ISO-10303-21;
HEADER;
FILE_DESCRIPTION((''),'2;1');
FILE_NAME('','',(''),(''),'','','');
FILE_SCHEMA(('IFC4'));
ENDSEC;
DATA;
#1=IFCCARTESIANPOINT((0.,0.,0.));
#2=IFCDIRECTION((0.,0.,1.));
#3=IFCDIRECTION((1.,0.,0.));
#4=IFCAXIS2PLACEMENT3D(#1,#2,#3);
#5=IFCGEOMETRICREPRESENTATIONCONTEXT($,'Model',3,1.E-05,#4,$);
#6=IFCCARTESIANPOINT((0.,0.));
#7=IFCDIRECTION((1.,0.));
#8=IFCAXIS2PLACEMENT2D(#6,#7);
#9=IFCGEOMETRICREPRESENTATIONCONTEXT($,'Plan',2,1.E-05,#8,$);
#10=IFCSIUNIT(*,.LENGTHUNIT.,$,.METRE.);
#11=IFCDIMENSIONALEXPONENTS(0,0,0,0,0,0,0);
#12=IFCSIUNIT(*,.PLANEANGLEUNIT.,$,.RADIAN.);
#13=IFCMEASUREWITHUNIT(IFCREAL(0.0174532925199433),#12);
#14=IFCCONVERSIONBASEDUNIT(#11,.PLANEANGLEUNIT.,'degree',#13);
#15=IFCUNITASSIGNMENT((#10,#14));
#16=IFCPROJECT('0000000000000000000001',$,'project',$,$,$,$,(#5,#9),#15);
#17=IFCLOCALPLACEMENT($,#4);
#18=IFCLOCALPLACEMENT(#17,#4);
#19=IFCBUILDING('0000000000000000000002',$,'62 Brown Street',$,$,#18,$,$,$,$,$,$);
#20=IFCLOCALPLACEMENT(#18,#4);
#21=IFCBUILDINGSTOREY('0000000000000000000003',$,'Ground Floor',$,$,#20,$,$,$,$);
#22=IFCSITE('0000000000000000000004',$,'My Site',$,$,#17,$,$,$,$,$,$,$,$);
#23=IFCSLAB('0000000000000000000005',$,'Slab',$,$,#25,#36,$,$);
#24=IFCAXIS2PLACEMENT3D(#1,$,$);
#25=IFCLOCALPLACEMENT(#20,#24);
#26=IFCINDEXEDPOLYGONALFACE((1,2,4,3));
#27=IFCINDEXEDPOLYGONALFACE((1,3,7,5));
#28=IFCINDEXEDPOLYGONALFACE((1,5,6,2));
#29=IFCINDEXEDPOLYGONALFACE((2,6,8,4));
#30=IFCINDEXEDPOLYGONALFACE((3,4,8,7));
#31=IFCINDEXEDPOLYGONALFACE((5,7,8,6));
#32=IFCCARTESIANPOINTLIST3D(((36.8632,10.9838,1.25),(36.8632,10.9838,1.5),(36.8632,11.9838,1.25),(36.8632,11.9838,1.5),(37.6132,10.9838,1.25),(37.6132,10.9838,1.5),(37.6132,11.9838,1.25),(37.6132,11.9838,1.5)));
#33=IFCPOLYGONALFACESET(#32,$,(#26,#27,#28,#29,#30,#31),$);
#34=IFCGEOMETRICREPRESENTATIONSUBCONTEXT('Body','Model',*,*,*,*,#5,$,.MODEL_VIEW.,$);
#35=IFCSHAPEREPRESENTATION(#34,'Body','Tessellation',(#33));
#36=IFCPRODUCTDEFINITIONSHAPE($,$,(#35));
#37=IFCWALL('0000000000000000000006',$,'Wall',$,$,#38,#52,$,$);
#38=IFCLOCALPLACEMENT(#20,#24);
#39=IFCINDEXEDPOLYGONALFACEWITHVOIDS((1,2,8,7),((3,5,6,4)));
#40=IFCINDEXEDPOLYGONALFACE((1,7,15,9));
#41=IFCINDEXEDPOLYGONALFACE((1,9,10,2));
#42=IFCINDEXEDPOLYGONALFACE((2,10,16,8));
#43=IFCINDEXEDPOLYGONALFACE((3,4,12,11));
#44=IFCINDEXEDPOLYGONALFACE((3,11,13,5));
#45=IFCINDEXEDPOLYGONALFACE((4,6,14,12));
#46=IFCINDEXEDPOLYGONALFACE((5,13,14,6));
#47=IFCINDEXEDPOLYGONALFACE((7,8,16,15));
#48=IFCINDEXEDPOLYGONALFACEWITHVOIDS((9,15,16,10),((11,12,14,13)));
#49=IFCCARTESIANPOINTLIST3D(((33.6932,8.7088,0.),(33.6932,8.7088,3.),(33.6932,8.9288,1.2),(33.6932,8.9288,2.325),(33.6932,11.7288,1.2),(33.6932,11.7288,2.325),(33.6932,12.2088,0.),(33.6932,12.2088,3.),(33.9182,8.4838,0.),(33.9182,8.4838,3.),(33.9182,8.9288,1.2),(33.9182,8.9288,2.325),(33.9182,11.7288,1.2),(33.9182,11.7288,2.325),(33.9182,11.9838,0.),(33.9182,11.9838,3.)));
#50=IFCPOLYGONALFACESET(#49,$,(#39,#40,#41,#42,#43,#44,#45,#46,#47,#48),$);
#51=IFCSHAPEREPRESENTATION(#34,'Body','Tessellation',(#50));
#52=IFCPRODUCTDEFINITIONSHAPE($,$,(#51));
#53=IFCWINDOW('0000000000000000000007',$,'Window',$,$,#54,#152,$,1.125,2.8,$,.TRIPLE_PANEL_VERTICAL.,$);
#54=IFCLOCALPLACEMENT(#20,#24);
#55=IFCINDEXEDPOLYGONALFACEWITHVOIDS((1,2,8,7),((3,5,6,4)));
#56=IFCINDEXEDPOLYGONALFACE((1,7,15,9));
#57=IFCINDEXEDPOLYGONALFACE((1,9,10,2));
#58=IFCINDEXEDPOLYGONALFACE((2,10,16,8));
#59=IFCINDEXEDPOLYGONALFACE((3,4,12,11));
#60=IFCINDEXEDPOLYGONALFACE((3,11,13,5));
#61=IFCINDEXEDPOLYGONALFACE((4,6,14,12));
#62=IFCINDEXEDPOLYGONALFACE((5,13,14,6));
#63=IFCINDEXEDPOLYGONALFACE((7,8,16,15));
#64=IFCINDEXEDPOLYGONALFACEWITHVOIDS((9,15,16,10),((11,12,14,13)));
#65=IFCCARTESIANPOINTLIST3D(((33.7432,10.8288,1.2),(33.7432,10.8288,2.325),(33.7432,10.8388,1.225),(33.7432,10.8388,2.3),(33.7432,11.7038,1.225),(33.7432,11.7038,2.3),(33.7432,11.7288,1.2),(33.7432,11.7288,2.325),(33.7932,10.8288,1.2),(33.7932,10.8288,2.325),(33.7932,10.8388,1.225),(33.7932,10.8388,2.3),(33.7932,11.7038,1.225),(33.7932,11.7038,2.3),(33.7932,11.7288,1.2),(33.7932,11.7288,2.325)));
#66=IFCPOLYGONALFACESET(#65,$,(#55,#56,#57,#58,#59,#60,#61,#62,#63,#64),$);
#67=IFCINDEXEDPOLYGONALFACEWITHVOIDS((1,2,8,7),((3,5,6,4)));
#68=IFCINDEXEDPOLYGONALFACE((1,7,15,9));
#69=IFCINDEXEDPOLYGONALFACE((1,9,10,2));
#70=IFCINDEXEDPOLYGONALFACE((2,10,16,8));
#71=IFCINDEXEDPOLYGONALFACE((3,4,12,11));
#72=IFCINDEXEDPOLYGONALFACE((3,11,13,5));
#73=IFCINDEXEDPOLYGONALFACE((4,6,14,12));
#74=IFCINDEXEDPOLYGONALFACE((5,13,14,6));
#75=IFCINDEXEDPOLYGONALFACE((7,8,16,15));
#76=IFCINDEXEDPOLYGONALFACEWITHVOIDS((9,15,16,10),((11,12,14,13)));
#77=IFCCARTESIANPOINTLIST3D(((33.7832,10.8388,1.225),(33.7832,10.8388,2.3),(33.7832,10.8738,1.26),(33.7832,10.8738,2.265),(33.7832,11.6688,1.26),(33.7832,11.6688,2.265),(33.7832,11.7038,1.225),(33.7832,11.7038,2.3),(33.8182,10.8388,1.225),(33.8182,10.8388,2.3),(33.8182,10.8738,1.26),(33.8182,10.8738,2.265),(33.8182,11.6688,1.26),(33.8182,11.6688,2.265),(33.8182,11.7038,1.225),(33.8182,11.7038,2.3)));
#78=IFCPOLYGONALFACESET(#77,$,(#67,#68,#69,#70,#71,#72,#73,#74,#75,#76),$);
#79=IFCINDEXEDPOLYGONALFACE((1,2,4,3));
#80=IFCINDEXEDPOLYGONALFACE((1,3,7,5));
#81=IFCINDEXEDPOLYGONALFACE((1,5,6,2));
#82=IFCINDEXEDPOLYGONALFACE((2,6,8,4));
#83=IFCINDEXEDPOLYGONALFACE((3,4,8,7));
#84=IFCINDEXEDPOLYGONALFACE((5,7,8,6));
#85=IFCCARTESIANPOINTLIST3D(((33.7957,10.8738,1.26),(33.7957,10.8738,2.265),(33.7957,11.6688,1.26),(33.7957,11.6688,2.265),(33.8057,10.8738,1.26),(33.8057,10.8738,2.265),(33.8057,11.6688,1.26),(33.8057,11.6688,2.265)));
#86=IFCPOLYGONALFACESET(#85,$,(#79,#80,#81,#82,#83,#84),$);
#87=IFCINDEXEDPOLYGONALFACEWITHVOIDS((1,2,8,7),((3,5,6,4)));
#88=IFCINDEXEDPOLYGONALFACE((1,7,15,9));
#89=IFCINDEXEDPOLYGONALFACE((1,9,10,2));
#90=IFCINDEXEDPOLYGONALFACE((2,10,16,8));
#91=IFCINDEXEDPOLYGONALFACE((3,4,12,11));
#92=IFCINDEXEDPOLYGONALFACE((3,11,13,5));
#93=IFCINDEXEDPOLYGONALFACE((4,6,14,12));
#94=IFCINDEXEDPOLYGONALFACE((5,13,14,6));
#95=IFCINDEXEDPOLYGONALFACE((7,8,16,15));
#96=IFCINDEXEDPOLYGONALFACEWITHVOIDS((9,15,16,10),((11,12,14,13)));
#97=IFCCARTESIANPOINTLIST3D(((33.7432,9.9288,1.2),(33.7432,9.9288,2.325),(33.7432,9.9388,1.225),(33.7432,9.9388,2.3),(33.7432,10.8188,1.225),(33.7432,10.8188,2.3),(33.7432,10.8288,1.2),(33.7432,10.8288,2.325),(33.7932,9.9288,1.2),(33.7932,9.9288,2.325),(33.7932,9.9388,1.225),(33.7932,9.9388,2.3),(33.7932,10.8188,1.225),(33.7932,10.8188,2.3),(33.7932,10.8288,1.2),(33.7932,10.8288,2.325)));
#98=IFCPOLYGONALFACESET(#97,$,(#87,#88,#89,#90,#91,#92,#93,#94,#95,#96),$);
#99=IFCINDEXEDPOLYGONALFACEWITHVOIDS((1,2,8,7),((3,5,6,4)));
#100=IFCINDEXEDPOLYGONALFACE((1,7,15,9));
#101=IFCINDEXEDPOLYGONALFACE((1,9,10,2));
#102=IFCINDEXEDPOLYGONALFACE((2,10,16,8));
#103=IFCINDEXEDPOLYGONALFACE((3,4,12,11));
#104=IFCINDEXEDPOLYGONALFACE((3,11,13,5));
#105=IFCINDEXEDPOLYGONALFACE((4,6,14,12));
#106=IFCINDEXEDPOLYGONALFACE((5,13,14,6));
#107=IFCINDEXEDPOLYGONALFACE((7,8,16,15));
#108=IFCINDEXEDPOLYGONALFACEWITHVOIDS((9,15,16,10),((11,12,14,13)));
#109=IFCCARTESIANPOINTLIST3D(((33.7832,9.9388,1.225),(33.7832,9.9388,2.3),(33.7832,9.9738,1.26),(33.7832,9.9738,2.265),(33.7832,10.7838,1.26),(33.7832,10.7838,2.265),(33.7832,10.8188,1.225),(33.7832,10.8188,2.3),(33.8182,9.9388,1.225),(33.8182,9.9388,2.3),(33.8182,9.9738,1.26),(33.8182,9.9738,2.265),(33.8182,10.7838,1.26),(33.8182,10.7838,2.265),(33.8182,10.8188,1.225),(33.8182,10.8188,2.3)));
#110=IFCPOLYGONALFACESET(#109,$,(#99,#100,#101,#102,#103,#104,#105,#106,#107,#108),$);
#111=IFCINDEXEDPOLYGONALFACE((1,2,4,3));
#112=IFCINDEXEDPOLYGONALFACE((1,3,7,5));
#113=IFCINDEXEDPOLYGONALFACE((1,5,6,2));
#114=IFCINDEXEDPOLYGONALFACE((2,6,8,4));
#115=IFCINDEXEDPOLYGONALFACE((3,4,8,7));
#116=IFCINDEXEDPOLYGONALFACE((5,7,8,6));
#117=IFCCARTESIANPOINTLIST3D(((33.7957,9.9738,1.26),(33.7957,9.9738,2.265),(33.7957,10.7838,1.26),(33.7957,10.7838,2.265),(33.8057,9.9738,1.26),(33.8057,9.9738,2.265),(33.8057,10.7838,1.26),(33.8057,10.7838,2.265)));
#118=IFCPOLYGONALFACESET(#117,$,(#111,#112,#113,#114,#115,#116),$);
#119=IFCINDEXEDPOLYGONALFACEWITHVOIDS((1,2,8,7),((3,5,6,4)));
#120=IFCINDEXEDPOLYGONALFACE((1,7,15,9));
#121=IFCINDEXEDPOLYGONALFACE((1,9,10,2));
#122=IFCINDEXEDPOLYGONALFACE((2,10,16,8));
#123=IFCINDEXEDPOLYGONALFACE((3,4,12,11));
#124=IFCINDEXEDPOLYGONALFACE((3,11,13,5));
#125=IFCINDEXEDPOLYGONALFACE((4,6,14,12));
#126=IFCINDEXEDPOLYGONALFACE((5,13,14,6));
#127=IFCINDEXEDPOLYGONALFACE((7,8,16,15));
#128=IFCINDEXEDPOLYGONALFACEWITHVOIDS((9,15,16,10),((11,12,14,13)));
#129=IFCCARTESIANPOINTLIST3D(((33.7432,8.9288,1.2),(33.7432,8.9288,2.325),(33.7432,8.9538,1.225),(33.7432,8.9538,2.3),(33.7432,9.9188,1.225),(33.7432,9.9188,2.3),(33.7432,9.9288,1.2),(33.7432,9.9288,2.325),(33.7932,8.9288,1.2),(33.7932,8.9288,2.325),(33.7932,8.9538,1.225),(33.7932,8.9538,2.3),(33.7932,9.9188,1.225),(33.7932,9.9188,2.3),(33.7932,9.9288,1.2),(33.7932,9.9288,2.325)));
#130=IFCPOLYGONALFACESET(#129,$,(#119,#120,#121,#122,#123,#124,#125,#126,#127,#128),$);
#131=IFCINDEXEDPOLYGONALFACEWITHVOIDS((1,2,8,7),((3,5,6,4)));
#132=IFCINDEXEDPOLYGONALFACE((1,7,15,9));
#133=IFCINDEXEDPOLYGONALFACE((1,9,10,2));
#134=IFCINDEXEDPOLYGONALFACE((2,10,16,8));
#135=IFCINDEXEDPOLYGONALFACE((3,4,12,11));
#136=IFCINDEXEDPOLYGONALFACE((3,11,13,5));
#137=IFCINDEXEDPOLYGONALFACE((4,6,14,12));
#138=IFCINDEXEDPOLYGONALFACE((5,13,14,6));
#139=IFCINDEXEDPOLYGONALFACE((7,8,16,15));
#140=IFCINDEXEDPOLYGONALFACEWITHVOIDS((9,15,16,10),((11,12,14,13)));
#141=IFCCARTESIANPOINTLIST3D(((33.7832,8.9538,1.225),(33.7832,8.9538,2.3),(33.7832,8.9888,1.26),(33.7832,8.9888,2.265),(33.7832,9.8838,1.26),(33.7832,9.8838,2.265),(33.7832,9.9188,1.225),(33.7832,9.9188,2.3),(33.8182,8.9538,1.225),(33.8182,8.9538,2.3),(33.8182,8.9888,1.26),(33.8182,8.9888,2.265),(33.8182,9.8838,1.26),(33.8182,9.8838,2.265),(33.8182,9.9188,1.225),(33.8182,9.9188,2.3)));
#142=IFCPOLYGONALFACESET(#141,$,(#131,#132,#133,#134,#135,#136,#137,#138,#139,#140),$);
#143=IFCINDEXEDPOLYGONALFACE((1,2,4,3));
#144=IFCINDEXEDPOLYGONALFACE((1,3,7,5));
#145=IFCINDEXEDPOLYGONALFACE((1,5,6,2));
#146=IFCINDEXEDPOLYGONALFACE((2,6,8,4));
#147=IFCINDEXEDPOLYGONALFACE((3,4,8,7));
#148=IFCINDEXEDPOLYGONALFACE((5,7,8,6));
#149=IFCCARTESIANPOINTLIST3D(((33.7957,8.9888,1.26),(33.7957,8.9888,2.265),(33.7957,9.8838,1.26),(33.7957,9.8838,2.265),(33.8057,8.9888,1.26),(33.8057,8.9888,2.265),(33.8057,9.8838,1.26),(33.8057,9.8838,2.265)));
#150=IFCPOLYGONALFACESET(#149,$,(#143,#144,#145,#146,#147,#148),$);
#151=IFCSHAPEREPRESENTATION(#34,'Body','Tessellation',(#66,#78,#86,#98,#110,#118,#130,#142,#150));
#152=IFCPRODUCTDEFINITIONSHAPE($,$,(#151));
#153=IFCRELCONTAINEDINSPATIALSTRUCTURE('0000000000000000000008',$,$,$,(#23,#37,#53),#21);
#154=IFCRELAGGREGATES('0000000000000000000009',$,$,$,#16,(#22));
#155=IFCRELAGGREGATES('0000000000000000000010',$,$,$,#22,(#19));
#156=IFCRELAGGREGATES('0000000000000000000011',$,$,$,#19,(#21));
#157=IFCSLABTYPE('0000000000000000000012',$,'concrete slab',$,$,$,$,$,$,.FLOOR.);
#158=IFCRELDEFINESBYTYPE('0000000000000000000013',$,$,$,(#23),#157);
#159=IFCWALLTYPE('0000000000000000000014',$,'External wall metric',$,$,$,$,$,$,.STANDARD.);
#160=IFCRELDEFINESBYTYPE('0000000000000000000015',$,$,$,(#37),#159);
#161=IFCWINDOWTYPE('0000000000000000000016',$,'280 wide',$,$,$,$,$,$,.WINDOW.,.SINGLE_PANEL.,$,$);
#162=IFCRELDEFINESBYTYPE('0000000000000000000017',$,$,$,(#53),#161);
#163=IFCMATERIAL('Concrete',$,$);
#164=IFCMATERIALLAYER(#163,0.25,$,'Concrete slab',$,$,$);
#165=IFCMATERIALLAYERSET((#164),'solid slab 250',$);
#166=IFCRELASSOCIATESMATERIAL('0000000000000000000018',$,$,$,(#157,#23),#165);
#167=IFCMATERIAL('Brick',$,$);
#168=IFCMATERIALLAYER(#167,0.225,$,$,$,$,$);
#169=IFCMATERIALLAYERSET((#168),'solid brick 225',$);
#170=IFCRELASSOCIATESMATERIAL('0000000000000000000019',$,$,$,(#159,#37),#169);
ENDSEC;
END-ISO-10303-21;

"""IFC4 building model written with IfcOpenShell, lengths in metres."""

from ifc_helpers import new_model, entity, si_unit, converted_unit, frame, origin_with_axes, origin_2d_with_axis, place, context, subcontext, project, spatial, line, indexed_curve, outline, extrude, clip, halfspace, shape, source, transform, mapped, material, layer, layer_set, layer_usage, type_object, type_shapes, element, fill, save


model = new_model("IFC4")

# Units and contexts
model_context = context("Model", 3, precision=1e-05, world=origin_with_axes())
plan_context = context("Plan", 2, precision=1e-05, world=origin_2d_with_axis())
body_context_1 = subcontext(model_context, "Body", "Model", "MODEL_VIEW")
body_context_2 = subcontext(plan_context, "Body", "Plan", "PLAN_VIEW")
ifc_project = project(units=[si_unit("LENGTHUNIT", "METRE"), converted_unit("PLANEANGLEUNIT", "degree", entity("IfcReal", 0.0174532925199433), si_unit("PLANEANGLEUNIT", "RADIAN"), dimensions=[0, 0, 0, 0, 0, 0, 0])], contexts=[model_context, plan_context])

# Site, building, storey
site_placement = place(None, origin_with_axes())
site = spatial("IfcSite", under=ifc_project, at=site_placement, Name="My Site")
building_placement = place(site_placement, origin_with_axes())
building = spatial("IfcBuilding", under=site, at=building_placement, Name="62 Brown Street")
storey_placement = place(building_placement, origin_with_axes())
storey = spatial("IfcBuildingStorey", under=building, at=storey_placement, Name="Ground Floor")

# Slab
ifc_material_1 = material(Name="Concrete")
ifc_layer_1 = layer(ifc_material_1, 0.25, Name="Concrete slab")
ifc_layer_set_1 = layer_set([ifc_layer_1], Name="solid slab 250")
ifc_layer_usage_1 = layer_usage(ifc_layer_set_1, "AXIS3", "POSITIVE", 0.0)
slab_type = type_object("IfcSlabType", Name="concrete slab", PredefinedType="FLOOR", material=ifc_layer_set_1)
slab_placement = place(storey_placement, frame((36.8632, 10.9838, 1.25), z_axis=(0.0, 0.0, 1.0), x_axis=(1.0, 0.0, 0.0)))
element("IfcSlab", 1, at=slab_placement, inside=storey, type_object=slab_type, material=ifc_layer_usage_1, Name="Slab", context=body_context_1, shape_type="SweptSolid", body=[
    extrude(outline(indexed_curve([(0.0, 0.0), (0.75, 0.0), (0.75, 1.0), (0.0, 1.0)], segments=[line(4, 1), line(1, 2), line(2, 3), line(3, 4)], self_intersect=False)), None, (0.0, 0.0, 1.0), 0.25),
])

# Wall, opening, window
ifc_material_2 = material(Name="Brick")
ifc_layer_2 = layer(ifc_material_2, 0.225)
ifc_layer_set_2 = layer_set([ifc_layer_2], Name="solid brick 225")
ifc_layer_usage_2 = layer_usage(ifc_layer_set_2, "AXIS2", "POSITIVE", 0.0)
wall_type_1 = type_object("IfcWallType", Name="External wall metric", PredefinedType="STANDARD", material=ifc_layer_set_2)
wall_1_placement = place(storey_placement, frame((33.6932, 12.2088, 0.0), z_axis=(0.0, 0.0, 1.0), x_axis=(0.0, -1.0, 0.0)))
wall_1 = element("IfcWall", 2, at=wall_1_placement, inside=storey, type_object=wall_type_1, material=ifc_layer_usage_2, Name="Wall", context=body_context_1, shape_type="Clipping", body=[
    clip(clip(extrude(outline(indexed_curve([(0.0, 0.0), (0.0, 0.225), (3.725, 0.225), (3.725, 0.0), (0.0, 0.0)], self_intersect=False)), origin_with_axes(), (0.0, 0.0, 1.0), 3.0), halfspace(frame((0.0, 0.0, 0.0), z_axis=(-0.674995, 0.675001, 0.0), x_axis=(0.225, 0.224998, 0.0)), False)), halfspace(frame((3.5, 0.0, 0.0), z_axis=(0.674995, -0.674999, 0.0), x_axis=(0.225, 0.224998, 0.0)), False)),
])
shared_shape_1 = source(origin_with_axes(), body_context_1, "Body", "SweptSolid", [
    extrude(outline(indexed_curve([(0.0, 0.0), (2.8, 0.0), (2.8, 1.125), (0.0, 1.125)], segments=[line(1, 2, 3, 4, 1)])), frame((0.0, -0.1, 0.0), z_axis=(0.0, -1.0, 0.0), x_axis=(1.0, 0.0, 0.0)), (0.0, 0.0, -1.0), 0.425),
])
opening_1_placement = place(wall_1_placement, frame((0.48, 0.0, 1.2), z_axis=(0.0, 0.0, 1.0), x_axis=(1.0, 0.0, 0.0)))
opening_1 = element("IfcOpeningElement", 3, at=opening_1_placement, cuts=wall_1, PredefinedType="OPENING", context=body_context_1, shape_type="MappedRepresentation", body=[
    mapped(shared_shape_1, transform((0.0, 0.0, 0.0), x_axis=(1.0, 0.0, 0.0), y_axis=(0.0, 1.0, 0.0), z_axis=(0.0, 0.0, 1.0), scale=1.0)),
])
window_type_1 = type_object("IfcWindowType", Name="280 wide", PartitioningType="SINGLE_PANEL", PredefinedType="WINDOW")
shared_shape_2 = source(origin_with_axes(), body_context_1, "Body", "SweptSolid", [
    extrude(outline(indexed_curve([(0.0, 0.0), (0.9, 0.0), (0.9, 1.125), (0.0, 1.125)], segments=[line(1, 2, 3, 4, 1)]), holes=[indexed_curve([(0.025, 0.025), (0.89, 0.025), (0.89, 1.1), (0.025, 1.1)], segments=[line(1, 2, 3, 4, 1)])]), frame((0.0, 0.05, 0.0), z_axis=(0.0, -1.0, 0.0), x_axis=(1.0, 0.0, 0.0)), (0.0, 0.0, -1.0), 0.05),
    extrude(outline(indexed_curve([(0.0, 0.0), (0.865, 0.0), (0.865, 1.075), (0.0, 1.075)], segments=[line(1, 2, 3, 4, 1)]), holes=[indexed_curve([(0.035, 0.035), (0.83, 0.035), (0.83, 1.04), (0.035, 1.04)], segments=[line(1, 2, 3, 4, 1)])]), frame((0.025, 0.09, 0.025), z_axis=(0.0, -1.0, 0.0), x_axis=(1.0, 0.0, 0.0)), (0.0, 0.0, -1.0), 0.035),
    extrude(outline(indexed_curve([(0.035, 0.035), (0.83, 0.035), (0.83, 1.04), (0.035, 1.04)], segments=[line(1, 2, 3, 4, 1)])), frame((0.025, 0.1025, 0.025), z_axis=(0.0, -1.0, 0.0), x_axis=(1.0, 0.0, 0.0)), (0.0, 0.0, -1.0), 0.01),
    extrude(outline(indexed_curve([(0.0, 0.0), (0.9, 0.0), (0.9, 1.125), (0.0, 1.125)], segments=[line(1, 2, 3, 4, 1)]), holes=[indexed_curve([(0.01, 0.025), (0.89, 0.025), (0.89, 1.1), (0.01, 1.1)], segments=[line(1, 2, 3, 4, 1)])]), frame((0.9, 0.05, 0.0), z_axis=(0.0, -1.0, 0.0), x_axis=(1.0, 0.0, 0.0)), (0.0, 0.0, -1.0), 0.05),
    extrude(outline(indexed_curve([(0.0, 0.0), (0.88, 0.0), (0.88, 1.075), (0.0, 1.075)], segments=[line(1, 2, 3, 4, 1)]), holes=[indexed_curve([(0.035, 0.035), (0.845, 0.035), (0.845, 1.04), (0.035, 1.04)], segments=[line(1, 2, 3, 4, 1)])]), frame((0.91, 0.09, 0.025), z_axis=(0.0, -1.0, 0.0), x_axis=(1.0, 0.0, 0.0)), (0.0, 0.0, -1.0), 0.035),
    extrude(outline(indexed_curve([(0.035, 0.035), (0.845, 0.035), (0.845, 1.04), (0.035, 1.04)], segments=[line(1, 2, 3, 4, 1)])), frame((0.91, 0.1025, 0.025), z_axis=(0.0, -1.0, 0.0), x_axis=(1.0, 0.0, 0.0)), (0.0, 0.0, -1.0), 0.01),
    extrude(outline(indexed_curve([(0.0, 0.0), (1.0, 0.0), (1.0, 1.125), (0.0, 1.125)], segments=[line(1, 2, 3, 4, 1)]), holes=[indexed_curve([(0.01, 0.025), (0.975, 0.025), (0.975, 1.1), (0.01, 1.1)], segments=[line(1, 2, 3, 4, 1)])]), frame((1.8, 0.05, 0.0), z_axis=(0.0, -1.0, 0.0), x_axis=(1.0, 0.0, 0.0)), (0.0, 0.0, -1.0), 0.05),
    extrude(outline(indexed_curve([(0.0, 0.0), (0.965, 0.0), (0.965, 1.075), (0.0, 1.075)], segments=[line(1, 2, 3, 4, 1)]), holes=[indexed_curve([(0.035, 0.035), (0.93, 0.035), (0.93, 1.04), (0.035, 1.04)], segments=[line(1, 2, 3, 4, 1)])]), frame((1.81, 0.09, 0.025), z_axis=(0.0, -1.0, 0.0), x_axis=(1.0, 0.0, 0.0)), (0.0, 0.0, -1.0), 0.035),
    extrude(outline(indexed_curve([(0.035, 0.035), (0.93, 0.035), (0.93, 1.04), (0.035, 1.04)], segments=[line(1, 2, 3, 4, 1)])), frame((1.81, 0.1025, 0.025), z_axis=(0.0, -1.0, 0.0), x_axis=(1.0, 0.0, 0.0)), (0.0, 0.0, -1.0), 0.01),
])
shared_shape_3 = source(origin_with_axes(), body_context_2, "Body", "Curve2D", [
    entity("IfcIndexedPolyCurve", entity("IfcCartesianPointList2D", [[0.025, 0.05], [0.89, 0.05]])),
    entity("IfcIndexedPolyCurve", entity("IfcCartesianPointList2D", [[0.0, 0.1], [0.025, 0.1], [0.025, 0.05], [0.0, 0.05]]), [entity("IfcLineIndex", [1, 2, 3, 4, 1])]),
    entity("IfcIndexedPolyCurve", entity("IfcCartesianPointList2D", [[0.9, 0.1], [0.89, 0.1], [0.89, 0.05], [0.9, 0.05]])),
    entity("IfcIndexedPolyCurve", entity("IfcCartesianPointList2D", [[0.025, 0.09], [0.06, 0.09], [0.06, 0.125], [0.025, 0.125]]), [entity("IfcLineIndex", [1, 2, 3, 4, 1])]),
    entity("IfcIndexedPolyCurve", entity("IfcCartesianPointList2D", [[0.89, 0.09], [0.855, 0.09], [0.855, 0.125], [0.89, 0.125]]), [entity("IfcLineIndex", [1, 2, 3, 4, 1])]),
    entity("IfcIndexedPolyCurve", entity("IfcCartesianPointList2D", [[0.06, 0.09], [0.855, 0.09]])),
    entity("IfcIndexedPolyCurve", entity("IfcCartesianPointList2D", [[0.06, 0.125], [0.855, 0.125]])),
    entity("IfcIndexedPolyCurve", entity("IfcCartesianPointList2D", [[0.06, 0.1075], [0.855, 0.1075]])),
    entity("IfcIndexedPolyCurve", entity("IfcCartesianPointList2D", [[0.91, 0.05], [1.79, 0.05]])),
    entity("IfcIndexedPolyCurve", entity("IfcCartesianPointList2D", [[0.9, 0.1], [0.91, 0.1], [0.91, 0.05], [0.9, 0.05]])),
    entity("IfcIndexedPolyCurve", entity("IfcCartesianPointList2D", [[1.8, 0.1], [1.79, 0.1], [1.79, 0.05], [1.8, 0.05]])),
    entity("IfcIndexedPolyCurve", entity("IfcCartesianPointList2D", [[0.91, 0.09], [0.945, 0.09], [0.945, 0.125], [0.91, 0.125]]), [entity("IfcLineIndex", [1, 2, 3, 4, 1])]),
    entity("IfcIndexedPolyCurve", entity("IfcCartesianPointList2D", [[1.79, 0.09], [1.755, 0.09], [1.755, 0.125], [1.79, 0.125]]), [entity("IfcLineIndex", [1, 2, 3, 4, 1])]),
    entity("IfcIndexedPolyCurve", entity("IfcCartesianPointList2D", [[0.945, 0.09], [1.755, 0.09]])),
    entity("IfcIndexedPolyCurve", entity("IfcCartesianPointList2D", [[0.945, 0.125], [1.755, 0.125]])),
    entity("IfcIndexedPolyCurve", entity("IfcCartesianPointList2D", [[0.945, 0.1075], [1.755, 0.1075]])),
    entity("IfcIndexedPolyCurve", entity("IfcCartesianPointList2D", [[1.81, 0.05], [2.775, 0.05]])),
    entity("IfcIndexedPolyCurve", entity("IfcCartesianPointList2D", [[1.8, 0.1], [1.81, 0.1], [1.81, 0.05], [1.8, 0.05]])),
    entity("IfcIndexedPolyCurve", entity("IfcCartesianPointList2D", [[2.8, 0.1], [2.775, 0.1], [2.775, 0.05], [2.8, 0.05]]), [entity("IfcLineIndex", [1, 2, 3, 4, 1])]),
    entity("IfcIndexedPolyCurve", entity("IfcCartesianPointList2D", [[1.81, 0.09], [1.845, 0.09], [1.845, 0.125], [1.81, 0.125]]), [entity("IfcLineIndex", [1, 2, 3, 4, 1])]),
    entity("IfcIndexedPolyCurve", entity("IfcCartesianPointList2D", [[2.775, 0.09], [2.74, 0.09], [2.74, 0.125], [2.775, 0.125]]), [entity("IfcLineIndex", [1, 2, 3, 4, 1])]),
    entity("IfcIndexedPolyCurve", entity("IfcCartesianPointList2D", [[1.845, 0.09], [2.74, 0.09]])),
    entity("IfcIndexedPolyCurve", entity("IfcCartesianPointList2D", [[1.845, 0.125], [2.74, 0.125]])),
    entity("IfcIndexedPolyCurve", entity("IfcCartesianPointList2D", [[1.845, 0.1075], [2.74, 0.1075]])),
])
type_shapes(window_type_1, [shared_shape_2, shared_shape_3])
window_1_placement = place(opening_1_placement, frame((0.0, 0.0, 0.0), z_axis=(0.0, 0.0, 1.0), x_axis=(1.0, 0.0, 0.0)))
window_1 = element("IfcWindow", 4, at=window_1_placement, inside=storey, type_object=window_type_1, Name="Window", OverallHeight=1.125, OverallWidth=2.8, PartitioningType="TRIPLE_PANEL_VERTICAL", shapes=[
    shape(body_context_1, "Body", "MappedRepresentation", [mapped(shared_shape_2, transform((0.0, 0.0, 0.0), x_axis=(1.0, 0.0, 0.0), y_axis=(0.0, 1.0, 0.0), z_axis=(0.0, 0.0, 1.0), scale=1.0))]),
    shape(body_context_2, "Body", "MappedRepresentation", [mapped(shared_shape_3, transform((0.0, 0.0, 0.0), x_axis=(1.0, 0.0, 0.0), y_axis=(0.0, 1.0, 0.0), z_axis=(0.0, 0.0, 1.0), scale=1.0))]),
])
fill(opening_1, window_1)

save(model, "model.ifc")
